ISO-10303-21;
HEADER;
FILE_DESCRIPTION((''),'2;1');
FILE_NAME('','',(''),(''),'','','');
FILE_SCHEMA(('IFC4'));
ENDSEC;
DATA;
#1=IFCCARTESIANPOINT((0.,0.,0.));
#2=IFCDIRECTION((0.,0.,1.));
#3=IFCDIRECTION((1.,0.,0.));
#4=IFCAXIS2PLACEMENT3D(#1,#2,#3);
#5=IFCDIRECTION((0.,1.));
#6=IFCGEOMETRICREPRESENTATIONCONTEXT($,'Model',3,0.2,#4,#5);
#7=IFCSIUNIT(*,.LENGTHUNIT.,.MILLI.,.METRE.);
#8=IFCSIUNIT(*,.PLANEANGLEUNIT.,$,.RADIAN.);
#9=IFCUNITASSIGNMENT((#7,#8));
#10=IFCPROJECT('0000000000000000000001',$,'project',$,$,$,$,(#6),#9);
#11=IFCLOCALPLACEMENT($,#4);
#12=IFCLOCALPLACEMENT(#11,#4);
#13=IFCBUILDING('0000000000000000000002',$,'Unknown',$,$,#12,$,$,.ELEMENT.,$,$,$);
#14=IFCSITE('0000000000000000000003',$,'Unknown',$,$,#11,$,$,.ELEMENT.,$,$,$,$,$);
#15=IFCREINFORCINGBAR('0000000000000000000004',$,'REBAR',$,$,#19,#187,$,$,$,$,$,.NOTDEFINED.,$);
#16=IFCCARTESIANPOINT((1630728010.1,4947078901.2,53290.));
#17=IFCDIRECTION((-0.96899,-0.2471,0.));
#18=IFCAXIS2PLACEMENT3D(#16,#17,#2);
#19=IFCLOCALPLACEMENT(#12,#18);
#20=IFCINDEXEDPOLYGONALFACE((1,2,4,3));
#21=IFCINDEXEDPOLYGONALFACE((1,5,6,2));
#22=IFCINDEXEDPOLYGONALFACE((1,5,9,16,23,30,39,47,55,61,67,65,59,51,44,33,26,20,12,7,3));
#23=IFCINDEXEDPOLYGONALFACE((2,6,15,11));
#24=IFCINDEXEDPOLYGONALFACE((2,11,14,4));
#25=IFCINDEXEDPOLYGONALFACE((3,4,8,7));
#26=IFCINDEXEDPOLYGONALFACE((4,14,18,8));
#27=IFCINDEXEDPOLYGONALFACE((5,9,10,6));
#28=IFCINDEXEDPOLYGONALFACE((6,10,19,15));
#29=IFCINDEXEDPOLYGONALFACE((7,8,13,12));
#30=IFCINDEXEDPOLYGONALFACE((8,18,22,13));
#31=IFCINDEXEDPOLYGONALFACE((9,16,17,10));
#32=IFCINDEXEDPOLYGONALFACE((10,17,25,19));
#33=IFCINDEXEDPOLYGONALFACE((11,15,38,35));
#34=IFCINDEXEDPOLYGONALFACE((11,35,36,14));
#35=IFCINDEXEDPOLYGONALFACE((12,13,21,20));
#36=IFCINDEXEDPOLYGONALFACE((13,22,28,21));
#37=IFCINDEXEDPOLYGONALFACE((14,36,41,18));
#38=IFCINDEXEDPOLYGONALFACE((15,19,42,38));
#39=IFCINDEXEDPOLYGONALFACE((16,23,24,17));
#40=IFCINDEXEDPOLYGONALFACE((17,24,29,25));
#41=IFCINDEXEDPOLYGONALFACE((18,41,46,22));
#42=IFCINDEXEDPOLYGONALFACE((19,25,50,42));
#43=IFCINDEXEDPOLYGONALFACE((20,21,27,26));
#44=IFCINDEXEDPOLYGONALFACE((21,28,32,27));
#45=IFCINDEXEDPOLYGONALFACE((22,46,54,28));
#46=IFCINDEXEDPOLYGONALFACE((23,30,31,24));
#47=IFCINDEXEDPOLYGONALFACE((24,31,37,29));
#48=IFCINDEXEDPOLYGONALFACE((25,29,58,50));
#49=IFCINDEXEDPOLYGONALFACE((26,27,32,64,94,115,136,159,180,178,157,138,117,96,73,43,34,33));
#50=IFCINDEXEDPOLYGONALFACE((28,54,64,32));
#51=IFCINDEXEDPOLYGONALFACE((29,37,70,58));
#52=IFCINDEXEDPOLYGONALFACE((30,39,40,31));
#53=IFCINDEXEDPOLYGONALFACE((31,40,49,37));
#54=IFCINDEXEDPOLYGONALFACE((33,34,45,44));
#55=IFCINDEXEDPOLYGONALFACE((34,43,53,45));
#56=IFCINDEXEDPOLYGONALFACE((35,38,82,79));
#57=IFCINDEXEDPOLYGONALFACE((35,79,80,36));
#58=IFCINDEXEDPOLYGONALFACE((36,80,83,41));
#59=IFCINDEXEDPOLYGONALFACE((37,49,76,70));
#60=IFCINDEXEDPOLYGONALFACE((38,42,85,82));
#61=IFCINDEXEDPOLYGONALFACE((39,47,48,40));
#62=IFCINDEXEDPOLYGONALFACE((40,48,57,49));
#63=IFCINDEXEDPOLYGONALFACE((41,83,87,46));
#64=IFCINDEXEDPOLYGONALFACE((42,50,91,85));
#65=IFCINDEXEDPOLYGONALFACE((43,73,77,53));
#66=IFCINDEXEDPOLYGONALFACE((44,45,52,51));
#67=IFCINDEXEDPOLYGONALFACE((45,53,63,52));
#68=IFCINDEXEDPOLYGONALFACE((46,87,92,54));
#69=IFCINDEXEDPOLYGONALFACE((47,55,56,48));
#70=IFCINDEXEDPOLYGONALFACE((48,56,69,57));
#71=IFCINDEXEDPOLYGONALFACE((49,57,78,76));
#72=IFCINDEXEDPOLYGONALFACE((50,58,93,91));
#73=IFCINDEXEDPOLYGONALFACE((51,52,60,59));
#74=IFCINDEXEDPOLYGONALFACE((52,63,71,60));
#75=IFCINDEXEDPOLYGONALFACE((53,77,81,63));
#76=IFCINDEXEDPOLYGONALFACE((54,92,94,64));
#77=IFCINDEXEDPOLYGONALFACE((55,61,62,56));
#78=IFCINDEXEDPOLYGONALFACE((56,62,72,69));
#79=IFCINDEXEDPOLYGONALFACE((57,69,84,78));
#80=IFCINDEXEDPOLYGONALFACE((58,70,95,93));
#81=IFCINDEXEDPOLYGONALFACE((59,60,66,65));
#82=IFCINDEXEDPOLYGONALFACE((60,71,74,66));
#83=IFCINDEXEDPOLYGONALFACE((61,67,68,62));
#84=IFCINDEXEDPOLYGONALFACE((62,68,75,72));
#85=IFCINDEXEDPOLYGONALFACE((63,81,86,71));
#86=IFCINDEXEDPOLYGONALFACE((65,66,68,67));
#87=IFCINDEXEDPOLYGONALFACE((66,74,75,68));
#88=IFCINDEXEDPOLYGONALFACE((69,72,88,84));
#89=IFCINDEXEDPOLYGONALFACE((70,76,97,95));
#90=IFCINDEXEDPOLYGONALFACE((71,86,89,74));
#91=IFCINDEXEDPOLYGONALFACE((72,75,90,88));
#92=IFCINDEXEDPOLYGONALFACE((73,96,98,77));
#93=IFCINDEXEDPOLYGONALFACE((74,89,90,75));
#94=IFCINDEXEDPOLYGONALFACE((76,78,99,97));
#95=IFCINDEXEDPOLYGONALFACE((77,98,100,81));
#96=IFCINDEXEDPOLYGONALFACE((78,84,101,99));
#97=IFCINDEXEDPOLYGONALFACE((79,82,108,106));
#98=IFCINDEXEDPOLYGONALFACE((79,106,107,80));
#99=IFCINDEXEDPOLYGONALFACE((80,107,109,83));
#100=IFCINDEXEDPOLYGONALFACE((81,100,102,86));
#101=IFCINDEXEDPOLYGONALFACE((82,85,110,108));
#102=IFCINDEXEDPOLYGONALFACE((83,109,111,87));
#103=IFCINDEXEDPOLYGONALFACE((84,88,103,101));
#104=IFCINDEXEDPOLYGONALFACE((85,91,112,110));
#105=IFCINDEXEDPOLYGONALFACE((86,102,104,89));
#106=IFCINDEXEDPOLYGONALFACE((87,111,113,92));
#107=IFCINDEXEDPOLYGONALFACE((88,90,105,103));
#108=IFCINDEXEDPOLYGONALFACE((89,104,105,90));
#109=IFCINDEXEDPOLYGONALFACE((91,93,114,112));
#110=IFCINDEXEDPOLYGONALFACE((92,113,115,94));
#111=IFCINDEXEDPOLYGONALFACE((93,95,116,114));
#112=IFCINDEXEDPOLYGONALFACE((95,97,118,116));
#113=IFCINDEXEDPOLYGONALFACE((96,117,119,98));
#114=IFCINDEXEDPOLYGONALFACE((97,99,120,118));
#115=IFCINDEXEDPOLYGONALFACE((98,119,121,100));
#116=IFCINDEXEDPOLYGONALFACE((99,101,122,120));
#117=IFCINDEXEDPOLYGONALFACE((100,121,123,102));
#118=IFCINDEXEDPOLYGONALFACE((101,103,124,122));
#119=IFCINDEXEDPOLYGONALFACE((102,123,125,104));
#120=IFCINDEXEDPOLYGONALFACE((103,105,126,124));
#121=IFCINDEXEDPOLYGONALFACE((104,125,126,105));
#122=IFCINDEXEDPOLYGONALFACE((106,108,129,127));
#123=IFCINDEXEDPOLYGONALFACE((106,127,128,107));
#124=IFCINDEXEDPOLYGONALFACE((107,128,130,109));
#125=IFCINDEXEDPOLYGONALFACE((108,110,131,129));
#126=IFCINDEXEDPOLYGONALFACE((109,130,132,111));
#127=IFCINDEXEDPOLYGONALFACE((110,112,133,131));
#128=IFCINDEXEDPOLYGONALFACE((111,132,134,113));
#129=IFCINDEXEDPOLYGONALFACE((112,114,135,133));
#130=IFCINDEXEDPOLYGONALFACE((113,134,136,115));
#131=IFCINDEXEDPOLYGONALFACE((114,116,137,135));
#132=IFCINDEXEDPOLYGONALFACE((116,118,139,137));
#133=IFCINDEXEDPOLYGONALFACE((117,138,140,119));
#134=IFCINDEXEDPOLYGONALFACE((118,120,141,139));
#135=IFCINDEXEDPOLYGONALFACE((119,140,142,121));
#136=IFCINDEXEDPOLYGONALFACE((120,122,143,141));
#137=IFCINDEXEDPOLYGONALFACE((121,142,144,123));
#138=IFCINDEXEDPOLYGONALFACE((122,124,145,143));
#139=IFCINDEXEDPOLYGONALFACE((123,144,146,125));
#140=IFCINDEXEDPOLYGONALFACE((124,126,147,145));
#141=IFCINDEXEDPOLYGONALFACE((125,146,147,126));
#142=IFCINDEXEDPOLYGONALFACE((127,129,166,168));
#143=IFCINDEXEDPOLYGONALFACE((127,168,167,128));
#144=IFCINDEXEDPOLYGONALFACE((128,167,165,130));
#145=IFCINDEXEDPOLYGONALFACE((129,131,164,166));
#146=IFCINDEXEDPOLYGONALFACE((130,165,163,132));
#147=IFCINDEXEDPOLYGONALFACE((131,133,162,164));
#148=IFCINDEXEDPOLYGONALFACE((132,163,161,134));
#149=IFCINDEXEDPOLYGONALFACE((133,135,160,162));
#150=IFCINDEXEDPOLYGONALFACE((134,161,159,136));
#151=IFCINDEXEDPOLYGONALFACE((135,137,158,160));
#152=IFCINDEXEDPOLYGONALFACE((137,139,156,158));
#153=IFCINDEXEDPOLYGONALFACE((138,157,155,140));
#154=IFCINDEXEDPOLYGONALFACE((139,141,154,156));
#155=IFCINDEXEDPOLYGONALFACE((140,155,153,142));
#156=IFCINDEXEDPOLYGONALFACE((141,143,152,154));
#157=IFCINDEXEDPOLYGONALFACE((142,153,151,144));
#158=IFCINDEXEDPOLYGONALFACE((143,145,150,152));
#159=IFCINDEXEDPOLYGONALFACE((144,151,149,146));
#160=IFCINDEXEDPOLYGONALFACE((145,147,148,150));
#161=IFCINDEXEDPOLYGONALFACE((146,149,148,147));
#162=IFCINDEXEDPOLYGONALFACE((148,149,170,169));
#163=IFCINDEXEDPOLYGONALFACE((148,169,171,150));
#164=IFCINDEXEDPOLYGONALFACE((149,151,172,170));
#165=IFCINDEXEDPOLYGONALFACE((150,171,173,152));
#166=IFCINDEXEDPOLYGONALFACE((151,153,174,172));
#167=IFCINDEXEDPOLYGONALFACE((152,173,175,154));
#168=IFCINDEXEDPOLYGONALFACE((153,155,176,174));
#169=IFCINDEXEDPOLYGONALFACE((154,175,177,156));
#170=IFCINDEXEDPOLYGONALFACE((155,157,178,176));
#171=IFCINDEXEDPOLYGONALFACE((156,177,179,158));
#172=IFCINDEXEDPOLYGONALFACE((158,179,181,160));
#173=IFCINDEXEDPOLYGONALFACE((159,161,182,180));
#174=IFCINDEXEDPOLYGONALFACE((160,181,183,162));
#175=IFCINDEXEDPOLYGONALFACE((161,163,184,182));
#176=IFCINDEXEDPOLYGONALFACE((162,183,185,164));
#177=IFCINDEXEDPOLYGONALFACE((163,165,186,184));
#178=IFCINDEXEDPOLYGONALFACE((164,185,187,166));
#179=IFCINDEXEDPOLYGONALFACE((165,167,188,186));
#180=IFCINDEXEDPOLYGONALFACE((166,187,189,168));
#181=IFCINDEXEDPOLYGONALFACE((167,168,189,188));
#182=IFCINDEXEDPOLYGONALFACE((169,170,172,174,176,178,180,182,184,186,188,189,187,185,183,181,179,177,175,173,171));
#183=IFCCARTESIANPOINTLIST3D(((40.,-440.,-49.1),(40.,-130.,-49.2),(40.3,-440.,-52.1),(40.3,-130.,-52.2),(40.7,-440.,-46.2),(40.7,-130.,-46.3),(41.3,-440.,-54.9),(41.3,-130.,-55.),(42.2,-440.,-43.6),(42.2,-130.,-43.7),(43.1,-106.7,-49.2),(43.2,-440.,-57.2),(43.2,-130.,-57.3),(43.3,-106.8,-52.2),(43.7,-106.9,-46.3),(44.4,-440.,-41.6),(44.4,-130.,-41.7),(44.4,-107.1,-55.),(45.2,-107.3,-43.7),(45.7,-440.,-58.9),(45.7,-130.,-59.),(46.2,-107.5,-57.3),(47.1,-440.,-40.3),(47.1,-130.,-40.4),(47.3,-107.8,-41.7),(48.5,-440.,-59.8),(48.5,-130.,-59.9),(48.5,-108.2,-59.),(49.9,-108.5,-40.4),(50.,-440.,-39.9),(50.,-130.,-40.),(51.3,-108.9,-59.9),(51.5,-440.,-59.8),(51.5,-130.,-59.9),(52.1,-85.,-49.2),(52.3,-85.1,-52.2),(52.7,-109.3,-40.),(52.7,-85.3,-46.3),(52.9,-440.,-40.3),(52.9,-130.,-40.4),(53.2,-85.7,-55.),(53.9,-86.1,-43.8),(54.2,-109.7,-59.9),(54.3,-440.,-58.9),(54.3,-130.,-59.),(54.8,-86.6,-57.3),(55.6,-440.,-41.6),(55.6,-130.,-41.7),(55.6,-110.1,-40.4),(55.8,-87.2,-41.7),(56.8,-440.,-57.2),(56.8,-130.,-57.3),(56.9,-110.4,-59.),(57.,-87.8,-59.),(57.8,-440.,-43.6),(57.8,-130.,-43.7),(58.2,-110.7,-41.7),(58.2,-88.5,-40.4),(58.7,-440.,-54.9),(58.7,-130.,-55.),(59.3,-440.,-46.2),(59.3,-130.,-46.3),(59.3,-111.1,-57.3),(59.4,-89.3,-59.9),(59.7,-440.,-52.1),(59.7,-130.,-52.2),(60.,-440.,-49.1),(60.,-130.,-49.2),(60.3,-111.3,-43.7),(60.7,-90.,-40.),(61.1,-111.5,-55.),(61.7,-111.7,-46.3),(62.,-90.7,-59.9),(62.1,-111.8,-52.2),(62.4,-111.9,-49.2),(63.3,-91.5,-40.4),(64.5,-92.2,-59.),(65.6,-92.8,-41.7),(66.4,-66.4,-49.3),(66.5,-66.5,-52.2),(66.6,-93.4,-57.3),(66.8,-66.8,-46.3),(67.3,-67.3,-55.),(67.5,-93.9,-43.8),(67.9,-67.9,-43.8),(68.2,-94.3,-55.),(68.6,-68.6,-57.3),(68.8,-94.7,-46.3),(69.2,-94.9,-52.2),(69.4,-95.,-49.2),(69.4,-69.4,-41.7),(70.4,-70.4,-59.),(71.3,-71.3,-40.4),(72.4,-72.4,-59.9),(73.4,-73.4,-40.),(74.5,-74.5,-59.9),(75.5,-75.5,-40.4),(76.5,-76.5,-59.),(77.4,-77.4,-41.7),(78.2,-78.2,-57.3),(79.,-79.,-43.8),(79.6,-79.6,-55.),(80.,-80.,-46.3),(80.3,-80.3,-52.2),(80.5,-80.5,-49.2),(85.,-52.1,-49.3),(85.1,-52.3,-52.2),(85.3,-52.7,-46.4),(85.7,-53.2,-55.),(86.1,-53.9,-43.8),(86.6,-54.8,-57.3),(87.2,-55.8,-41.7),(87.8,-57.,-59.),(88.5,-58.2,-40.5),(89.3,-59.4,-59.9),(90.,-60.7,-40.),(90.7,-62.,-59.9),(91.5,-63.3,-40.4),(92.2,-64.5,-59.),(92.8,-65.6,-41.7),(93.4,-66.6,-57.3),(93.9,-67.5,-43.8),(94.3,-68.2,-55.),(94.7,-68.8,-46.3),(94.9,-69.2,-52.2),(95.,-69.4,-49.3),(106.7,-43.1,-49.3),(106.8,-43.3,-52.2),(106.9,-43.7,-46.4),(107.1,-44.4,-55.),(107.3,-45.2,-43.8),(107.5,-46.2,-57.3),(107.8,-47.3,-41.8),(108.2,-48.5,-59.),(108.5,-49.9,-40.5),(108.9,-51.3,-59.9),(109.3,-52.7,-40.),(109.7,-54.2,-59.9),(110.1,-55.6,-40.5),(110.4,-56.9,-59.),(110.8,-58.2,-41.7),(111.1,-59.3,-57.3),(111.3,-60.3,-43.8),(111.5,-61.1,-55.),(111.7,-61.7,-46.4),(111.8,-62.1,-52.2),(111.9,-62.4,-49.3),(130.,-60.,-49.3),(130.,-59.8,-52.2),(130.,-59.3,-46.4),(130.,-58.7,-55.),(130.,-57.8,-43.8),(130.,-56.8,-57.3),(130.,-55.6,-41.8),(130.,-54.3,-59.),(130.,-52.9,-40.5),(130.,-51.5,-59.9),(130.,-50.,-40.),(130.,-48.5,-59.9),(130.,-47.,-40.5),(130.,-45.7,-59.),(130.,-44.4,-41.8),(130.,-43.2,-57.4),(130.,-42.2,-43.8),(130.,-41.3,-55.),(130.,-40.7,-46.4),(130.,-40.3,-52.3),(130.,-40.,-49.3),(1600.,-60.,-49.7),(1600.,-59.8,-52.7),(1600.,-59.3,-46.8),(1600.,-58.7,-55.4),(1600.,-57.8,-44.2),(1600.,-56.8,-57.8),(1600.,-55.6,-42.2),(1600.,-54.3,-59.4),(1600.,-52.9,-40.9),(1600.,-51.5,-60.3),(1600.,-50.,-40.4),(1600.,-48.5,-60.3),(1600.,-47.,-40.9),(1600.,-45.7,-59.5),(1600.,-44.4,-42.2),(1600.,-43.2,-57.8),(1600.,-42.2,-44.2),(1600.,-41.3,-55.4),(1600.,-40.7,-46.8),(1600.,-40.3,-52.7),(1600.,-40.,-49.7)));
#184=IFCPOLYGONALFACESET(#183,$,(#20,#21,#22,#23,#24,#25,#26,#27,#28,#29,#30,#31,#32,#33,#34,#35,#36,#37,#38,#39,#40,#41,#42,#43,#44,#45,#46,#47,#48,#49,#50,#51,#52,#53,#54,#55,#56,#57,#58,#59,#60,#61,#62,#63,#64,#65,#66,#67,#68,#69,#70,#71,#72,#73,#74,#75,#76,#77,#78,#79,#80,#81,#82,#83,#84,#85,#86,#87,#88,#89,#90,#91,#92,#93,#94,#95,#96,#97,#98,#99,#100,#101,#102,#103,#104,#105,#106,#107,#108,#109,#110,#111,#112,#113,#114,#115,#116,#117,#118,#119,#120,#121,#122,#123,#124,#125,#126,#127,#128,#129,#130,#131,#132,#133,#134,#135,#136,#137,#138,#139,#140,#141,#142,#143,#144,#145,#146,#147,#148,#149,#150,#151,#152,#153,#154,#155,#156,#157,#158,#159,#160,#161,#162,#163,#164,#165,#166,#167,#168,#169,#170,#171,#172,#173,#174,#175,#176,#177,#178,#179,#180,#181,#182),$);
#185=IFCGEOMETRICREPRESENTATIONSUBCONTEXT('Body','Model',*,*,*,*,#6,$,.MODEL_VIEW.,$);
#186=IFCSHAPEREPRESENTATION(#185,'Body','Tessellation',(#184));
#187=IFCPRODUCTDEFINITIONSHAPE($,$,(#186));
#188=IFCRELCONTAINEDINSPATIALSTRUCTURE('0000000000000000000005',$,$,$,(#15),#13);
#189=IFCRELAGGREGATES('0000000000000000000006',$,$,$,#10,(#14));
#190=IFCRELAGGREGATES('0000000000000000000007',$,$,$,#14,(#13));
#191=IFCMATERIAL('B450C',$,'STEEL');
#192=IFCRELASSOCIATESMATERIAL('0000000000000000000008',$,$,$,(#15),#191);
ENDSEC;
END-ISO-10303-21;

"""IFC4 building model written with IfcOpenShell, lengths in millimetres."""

from ifc_helpers import new_model, entity, si_unit, direction, frame, origin_with_axes, place, context, subcontext, project, spatial, material, element, save


model = new_model("IFC4")

# Units and contexts
model_context = context("Model", 3, precision=0.2, world=origin_with_axes(), true_north=direction((0.0, 1.0)))
body_context = subcontext(model_context, "Body", "Model", "MODEL_VIEW")
ifc_project = project(units=[si_unit("LENGTHUNIT", "METRE", prefix="MILLI"), si_unit("PLANEANGLEUNIT", "RADIAN")], contexts=[model_context])

# Site, building
site_placement = place(None, origin_with_axes())
site = spatial("IfcSite", under=ifc_project, at=site_placement, Name="Unknown", CompositionType="ELEMENT")
building_placement = place(site_placement, origin_with_axes())
building = spatial("IfcBuilding", under=site, at=building_placement, Name="Unknown", CompositionType="ELEMENT")

# Reinforcing bar
ifc_material = material(Name="B450C", Category="STEEL")
reinforcing_bar_1_placement = place(building_placement, frame((1630728010.1, 4947078901.2, 53290.0), z_axis=(-0.96899, -0.2471, 0.0), x_axis=(0.0, 0.0, 1.0)))
element("IfcReinforcingBar", 1, at=reinforcing_bar_1_placement, inside=building, material=ifc_material, Name="REBAR", PredefinedType="NOTDEFINED", context=body_context, shape_type="AdvancedSweptSolid", body=[
    entity("IfcSweptDiskSolid", entity("IfcIndexedPolyCurve", entity("IfcCartesianPointList3D", [[50.0, -440.0, -49.9], [50.0, -130.0, -50.0], [73.4, -73.4, -50.0], [130.0, -50.0, -50.0], [1600.0, -50.0, -50.4]]), [entity("IfcLineIndex", [1, 2]), entity("IfcArcIndex", [2, 3, 4]), entity("IfcLineIndex", [4, 5])]), 10.0),
])

save(model, "model.ifc")
